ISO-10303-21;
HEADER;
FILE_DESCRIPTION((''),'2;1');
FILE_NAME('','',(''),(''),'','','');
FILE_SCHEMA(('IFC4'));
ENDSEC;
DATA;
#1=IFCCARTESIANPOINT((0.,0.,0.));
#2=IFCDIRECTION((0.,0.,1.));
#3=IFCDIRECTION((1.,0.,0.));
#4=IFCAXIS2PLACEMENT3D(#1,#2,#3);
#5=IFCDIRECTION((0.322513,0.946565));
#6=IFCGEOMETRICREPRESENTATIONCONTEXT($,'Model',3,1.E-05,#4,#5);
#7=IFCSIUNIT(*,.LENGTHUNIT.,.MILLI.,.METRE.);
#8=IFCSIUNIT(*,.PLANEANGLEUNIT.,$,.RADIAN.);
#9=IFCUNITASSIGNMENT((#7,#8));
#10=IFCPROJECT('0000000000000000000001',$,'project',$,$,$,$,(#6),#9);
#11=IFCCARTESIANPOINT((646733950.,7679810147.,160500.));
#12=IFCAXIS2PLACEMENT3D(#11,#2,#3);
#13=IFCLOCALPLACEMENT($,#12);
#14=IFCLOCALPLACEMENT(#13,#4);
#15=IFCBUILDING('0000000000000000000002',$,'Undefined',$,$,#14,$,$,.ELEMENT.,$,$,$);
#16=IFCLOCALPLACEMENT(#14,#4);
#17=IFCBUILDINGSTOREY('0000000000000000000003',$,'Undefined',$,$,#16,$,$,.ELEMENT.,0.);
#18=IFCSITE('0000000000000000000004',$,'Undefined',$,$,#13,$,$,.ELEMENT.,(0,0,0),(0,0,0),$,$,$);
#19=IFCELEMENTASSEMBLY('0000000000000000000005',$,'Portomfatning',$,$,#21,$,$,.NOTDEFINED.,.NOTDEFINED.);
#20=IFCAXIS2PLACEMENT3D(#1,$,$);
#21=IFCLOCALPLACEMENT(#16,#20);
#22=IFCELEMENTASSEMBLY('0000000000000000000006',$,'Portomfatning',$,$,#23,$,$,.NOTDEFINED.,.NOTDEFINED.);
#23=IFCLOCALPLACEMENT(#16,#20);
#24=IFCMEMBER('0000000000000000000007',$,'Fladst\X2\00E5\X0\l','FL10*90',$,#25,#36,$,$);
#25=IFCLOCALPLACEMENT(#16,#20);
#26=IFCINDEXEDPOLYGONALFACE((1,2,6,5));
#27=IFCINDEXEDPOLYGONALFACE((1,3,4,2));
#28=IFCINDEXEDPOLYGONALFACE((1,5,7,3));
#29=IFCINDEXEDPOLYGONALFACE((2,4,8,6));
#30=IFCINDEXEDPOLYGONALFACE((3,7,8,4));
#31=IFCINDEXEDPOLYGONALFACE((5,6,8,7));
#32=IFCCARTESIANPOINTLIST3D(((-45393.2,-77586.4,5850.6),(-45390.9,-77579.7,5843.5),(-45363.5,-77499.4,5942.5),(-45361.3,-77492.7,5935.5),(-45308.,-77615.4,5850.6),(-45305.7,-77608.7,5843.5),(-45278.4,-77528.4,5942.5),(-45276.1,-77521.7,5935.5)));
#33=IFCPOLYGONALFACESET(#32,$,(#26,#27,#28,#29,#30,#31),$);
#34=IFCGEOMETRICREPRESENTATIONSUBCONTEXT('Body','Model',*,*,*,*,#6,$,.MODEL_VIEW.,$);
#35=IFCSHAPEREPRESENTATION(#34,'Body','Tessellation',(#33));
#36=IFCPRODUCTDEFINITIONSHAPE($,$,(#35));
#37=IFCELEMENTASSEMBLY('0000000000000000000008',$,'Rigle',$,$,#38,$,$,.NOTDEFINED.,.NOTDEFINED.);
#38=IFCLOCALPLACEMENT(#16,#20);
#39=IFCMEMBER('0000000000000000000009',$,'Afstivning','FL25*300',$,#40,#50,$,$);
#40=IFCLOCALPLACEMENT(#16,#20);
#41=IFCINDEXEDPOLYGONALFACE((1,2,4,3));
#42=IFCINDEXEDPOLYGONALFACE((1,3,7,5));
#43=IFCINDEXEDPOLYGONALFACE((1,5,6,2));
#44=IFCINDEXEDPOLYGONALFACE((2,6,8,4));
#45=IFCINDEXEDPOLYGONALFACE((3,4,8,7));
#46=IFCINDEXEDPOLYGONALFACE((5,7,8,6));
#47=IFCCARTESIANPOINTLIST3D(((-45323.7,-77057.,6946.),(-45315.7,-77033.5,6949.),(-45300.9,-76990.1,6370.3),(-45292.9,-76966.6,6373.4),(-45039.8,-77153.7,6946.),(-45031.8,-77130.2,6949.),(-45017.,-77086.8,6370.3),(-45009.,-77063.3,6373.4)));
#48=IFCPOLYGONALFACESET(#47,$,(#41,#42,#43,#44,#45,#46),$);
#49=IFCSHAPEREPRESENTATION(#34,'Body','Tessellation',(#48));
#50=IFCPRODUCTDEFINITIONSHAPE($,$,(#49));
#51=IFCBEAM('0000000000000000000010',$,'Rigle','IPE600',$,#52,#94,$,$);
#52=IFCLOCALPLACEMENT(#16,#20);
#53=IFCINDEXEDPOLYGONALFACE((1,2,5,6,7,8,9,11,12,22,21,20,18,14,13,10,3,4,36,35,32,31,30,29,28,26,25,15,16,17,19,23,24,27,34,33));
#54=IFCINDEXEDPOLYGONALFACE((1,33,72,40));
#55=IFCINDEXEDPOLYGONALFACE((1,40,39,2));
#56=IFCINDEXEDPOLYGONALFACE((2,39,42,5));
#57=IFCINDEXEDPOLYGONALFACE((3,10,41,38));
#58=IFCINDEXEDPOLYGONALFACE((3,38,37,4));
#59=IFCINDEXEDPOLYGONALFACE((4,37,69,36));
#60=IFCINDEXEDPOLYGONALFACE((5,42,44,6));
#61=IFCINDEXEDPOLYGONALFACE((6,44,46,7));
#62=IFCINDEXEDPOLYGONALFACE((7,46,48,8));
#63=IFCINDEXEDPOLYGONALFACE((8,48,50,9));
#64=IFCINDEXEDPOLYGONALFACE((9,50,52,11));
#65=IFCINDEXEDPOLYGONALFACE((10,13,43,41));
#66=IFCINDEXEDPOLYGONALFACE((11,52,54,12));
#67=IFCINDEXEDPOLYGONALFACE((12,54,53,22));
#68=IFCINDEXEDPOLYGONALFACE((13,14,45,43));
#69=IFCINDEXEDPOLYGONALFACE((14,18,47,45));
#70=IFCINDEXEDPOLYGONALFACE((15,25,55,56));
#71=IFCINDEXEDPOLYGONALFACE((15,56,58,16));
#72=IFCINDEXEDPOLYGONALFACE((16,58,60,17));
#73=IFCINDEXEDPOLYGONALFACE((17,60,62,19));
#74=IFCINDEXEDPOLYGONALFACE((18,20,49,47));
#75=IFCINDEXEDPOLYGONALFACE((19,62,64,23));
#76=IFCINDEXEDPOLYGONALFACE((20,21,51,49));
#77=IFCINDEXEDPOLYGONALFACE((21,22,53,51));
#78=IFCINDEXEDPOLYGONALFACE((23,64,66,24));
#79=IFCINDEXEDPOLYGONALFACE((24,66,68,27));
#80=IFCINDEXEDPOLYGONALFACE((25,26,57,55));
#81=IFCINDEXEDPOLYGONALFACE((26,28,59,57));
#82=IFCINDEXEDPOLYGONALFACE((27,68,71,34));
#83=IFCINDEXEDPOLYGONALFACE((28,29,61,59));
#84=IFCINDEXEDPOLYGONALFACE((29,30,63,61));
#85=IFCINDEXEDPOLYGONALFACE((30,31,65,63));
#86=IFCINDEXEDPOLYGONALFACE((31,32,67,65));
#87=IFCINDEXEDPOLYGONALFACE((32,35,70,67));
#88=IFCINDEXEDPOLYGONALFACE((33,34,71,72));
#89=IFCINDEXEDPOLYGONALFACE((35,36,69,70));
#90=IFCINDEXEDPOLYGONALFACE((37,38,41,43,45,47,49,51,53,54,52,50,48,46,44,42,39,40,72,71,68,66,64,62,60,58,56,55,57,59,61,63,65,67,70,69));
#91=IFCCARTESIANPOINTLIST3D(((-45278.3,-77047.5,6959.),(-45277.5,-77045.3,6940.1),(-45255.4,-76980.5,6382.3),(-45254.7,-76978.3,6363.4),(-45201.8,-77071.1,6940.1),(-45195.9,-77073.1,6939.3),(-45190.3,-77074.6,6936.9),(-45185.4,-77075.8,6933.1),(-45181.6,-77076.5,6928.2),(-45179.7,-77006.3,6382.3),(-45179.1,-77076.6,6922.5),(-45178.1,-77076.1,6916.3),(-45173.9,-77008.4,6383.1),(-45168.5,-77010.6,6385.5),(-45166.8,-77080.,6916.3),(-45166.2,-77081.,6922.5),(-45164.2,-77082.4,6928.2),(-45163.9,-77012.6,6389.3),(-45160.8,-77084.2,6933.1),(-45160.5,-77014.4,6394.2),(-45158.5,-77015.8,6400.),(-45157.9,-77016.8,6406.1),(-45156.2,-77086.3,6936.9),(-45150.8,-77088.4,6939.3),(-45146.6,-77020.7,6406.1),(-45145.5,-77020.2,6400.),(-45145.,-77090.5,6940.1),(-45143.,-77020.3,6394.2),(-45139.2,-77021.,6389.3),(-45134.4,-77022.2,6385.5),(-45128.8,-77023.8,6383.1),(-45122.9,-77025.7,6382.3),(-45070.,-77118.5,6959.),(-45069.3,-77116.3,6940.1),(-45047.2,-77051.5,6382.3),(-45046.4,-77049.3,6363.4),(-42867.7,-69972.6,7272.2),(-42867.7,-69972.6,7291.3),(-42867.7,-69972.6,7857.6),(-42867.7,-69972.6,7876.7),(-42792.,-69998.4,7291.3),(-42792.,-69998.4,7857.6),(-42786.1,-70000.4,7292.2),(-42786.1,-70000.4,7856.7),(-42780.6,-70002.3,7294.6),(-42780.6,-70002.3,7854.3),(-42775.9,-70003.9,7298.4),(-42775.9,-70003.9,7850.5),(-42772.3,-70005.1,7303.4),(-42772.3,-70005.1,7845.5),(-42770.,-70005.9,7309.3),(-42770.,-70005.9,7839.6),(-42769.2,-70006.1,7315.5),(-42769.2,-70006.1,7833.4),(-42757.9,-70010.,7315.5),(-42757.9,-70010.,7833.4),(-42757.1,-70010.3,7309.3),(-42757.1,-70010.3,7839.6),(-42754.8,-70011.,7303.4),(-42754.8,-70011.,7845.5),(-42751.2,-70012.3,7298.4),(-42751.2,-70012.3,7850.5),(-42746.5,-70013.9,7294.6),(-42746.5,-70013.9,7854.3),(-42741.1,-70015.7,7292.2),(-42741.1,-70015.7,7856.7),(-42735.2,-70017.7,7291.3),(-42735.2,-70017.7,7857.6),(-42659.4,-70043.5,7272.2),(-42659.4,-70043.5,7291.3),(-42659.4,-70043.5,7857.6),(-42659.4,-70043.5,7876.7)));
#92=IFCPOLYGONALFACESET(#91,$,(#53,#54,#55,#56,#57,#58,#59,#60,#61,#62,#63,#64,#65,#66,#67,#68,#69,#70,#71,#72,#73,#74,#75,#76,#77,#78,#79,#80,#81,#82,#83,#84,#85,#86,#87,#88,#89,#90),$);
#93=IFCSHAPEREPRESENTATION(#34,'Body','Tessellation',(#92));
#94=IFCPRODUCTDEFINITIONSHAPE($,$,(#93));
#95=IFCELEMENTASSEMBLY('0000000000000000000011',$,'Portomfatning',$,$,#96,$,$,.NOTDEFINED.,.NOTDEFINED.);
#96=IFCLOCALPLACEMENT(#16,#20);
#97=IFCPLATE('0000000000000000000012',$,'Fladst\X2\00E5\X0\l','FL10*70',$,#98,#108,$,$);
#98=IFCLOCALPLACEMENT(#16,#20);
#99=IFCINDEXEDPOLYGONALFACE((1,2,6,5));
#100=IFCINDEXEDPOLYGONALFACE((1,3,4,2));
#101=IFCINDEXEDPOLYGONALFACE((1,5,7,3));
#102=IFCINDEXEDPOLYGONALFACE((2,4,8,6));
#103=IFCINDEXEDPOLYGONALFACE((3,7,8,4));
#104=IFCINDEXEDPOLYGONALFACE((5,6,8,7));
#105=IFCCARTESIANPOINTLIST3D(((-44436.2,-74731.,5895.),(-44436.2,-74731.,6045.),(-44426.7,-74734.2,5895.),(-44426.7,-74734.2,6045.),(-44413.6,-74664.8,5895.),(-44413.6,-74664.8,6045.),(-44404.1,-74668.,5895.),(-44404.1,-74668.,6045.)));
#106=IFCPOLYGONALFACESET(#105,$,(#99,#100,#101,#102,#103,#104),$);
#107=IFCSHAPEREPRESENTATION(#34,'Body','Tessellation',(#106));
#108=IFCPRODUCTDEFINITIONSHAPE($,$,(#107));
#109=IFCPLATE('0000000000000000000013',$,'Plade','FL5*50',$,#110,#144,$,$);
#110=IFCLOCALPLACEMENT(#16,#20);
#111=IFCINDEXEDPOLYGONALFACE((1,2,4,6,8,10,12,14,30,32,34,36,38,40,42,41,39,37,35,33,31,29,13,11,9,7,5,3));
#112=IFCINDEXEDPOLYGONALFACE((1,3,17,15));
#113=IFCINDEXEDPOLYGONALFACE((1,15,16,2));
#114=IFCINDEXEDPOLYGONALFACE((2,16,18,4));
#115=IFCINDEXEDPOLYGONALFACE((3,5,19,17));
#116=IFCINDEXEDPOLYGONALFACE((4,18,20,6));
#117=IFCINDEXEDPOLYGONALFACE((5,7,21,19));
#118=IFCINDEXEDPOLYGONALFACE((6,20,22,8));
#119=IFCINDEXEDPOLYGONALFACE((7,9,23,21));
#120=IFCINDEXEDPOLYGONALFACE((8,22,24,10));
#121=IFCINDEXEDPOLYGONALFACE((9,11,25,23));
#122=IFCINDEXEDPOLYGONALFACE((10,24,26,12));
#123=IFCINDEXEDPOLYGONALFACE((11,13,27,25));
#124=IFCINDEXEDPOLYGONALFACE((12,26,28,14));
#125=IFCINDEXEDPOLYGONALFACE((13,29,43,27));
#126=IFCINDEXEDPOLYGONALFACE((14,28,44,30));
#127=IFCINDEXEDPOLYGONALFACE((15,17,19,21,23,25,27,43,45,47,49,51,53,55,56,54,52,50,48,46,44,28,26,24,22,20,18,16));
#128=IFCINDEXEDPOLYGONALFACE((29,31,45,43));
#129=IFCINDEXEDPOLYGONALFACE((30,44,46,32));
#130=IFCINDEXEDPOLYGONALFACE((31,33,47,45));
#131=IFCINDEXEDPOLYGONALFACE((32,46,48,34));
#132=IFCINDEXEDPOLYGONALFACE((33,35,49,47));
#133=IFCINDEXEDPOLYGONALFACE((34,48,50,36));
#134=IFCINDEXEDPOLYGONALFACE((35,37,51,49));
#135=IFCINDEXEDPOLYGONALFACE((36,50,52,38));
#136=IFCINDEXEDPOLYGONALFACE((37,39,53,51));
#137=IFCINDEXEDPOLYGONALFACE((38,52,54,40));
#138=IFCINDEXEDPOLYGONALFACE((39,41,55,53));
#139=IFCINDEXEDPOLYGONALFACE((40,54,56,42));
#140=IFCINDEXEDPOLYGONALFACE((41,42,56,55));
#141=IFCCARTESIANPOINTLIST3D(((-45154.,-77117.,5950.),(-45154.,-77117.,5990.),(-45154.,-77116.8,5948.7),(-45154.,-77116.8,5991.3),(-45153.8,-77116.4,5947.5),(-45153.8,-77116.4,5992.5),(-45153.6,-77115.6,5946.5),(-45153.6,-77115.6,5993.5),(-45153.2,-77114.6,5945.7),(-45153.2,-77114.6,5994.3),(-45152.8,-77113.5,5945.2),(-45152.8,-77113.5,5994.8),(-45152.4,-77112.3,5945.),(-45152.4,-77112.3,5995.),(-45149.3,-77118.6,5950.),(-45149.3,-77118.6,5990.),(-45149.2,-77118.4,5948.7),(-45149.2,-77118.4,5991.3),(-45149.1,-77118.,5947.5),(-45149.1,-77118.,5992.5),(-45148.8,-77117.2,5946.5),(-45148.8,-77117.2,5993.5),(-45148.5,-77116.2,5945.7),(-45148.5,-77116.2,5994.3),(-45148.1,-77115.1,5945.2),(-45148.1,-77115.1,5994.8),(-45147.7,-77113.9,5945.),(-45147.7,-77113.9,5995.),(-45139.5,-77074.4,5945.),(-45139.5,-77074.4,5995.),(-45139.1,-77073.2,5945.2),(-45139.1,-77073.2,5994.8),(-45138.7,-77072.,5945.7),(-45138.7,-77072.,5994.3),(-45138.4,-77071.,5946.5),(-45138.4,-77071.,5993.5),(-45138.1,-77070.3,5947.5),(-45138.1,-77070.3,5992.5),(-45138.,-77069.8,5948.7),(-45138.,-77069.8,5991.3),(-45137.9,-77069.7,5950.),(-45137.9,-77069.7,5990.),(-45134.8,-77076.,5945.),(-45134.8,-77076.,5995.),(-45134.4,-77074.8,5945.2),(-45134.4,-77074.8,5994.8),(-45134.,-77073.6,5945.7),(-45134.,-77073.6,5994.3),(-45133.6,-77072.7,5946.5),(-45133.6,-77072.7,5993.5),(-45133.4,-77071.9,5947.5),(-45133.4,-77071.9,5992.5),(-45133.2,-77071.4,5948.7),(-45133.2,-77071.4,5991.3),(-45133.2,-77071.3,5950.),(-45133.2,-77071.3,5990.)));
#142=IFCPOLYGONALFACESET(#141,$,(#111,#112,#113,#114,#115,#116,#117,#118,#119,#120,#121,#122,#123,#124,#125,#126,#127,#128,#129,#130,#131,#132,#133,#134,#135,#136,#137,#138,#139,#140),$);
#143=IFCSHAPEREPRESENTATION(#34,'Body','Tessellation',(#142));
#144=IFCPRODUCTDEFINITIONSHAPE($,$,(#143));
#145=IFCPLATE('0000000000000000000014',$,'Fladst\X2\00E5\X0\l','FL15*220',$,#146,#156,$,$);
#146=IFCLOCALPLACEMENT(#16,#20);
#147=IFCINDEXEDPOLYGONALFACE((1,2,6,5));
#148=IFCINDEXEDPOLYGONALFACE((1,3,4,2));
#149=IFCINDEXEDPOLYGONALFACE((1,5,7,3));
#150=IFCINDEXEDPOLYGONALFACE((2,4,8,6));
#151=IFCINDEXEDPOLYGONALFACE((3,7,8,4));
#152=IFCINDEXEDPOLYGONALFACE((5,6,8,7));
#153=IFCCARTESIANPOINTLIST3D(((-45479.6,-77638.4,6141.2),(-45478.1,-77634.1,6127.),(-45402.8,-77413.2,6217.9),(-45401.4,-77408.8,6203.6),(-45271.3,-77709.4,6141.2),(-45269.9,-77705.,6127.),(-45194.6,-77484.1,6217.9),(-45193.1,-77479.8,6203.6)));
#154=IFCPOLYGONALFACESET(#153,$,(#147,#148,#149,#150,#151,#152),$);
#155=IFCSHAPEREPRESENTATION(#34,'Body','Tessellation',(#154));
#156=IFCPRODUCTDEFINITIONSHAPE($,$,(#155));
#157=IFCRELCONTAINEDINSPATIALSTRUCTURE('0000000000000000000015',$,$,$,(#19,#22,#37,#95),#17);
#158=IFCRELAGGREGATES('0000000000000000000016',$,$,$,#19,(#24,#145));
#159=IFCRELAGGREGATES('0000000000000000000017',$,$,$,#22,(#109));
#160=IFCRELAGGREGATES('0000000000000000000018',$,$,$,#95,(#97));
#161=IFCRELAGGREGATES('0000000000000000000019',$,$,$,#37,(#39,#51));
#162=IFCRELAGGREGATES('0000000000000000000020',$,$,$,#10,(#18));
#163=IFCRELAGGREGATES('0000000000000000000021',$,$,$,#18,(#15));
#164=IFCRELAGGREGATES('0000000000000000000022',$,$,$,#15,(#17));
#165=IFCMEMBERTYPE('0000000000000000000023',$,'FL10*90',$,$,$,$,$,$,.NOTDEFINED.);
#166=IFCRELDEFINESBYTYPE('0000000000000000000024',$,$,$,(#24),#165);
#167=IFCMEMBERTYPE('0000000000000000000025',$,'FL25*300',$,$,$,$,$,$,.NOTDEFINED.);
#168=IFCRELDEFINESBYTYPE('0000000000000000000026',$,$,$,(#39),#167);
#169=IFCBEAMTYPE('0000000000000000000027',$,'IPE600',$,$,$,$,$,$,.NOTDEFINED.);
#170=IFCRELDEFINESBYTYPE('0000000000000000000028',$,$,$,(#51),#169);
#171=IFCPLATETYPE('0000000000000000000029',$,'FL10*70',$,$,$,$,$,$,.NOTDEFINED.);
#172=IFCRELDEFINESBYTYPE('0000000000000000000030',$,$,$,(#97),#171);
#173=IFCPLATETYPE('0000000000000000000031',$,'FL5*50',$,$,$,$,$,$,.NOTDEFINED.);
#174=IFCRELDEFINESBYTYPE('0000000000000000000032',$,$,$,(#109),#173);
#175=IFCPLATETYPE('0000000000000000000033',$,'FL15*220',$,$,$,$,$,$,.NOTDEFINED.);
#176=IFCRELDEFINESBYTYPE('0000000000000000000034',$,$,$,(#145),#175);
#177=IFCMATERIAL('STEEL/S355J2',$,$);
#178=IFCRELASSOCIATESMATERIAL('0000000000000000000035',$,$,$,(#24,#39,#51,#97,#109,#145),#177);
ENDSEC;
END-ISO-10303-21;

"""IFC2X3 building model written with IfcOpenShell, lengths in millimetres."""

from ifc_helpers import new_model, si_unit, direction, frame, frame_2d, origin_with_axes, origin_2d_with_axis, place, context, subcontext, project, spatial, polyline, circle_curve, parameter, trimmed, segment, composite_curve, rectangle, i_section, outline, extrude, clip, halfspace, material, type_object, element, aggregate, save


model = new_model("IFC2X3")

# Units and contexts
model_context = context("Model", 3, precision=1e-05, world=origin_with_axes(), true_north=direction((0.322513, 0.946565)))
body_context = subcontext(model_context, "Body", "Model", "MODEL_VIEW")
ifc_project = project(units=[si_unit("LENGTHUNIT", "METRE", prefix="MILLI"), si_unit("PLANEANGLEUNIT", "RADIAN")], contexts=[model_context])

# Site, building, storey
site_placement = place(None, frame((646733950.0, 7679810147.0, 160500.0), z_axis=(0.0, 0.0, 1.0), x_axis=(1.0, 0.0, 0.0)))
site = spatial("IfcSite", under=ifc_project, at=site_placement, Name="Undefined", CompositionType="ELEMENT", RefLatitude=(0, 0, 0), RefLongitude=(0, 0, 0))
building_placement = place(site_placement, origin_with_axes())
building = spatial("IfcBuilding", under=site, at=building_placement, Name="Undefined", CompositionType="ELEMENT")
storey_placement = place(building_placement, origin_with_axes())
storey = spatial("IfcBuildingStorey", under=building, at=storey_placement, Name="Undefined", CompositionType="ELEMENT", Elevation=0.0)

# Element assembly
assembly_1_placement = place(storey_placement, origin_with_axes())
assembly_1 = element("IfcElementAssembly", 1, at=assembly_1_placement, inside=storey, Name="Portomfatning", AssemblyPlace="NOTDEFINED", PredefinedType="NOTDEFINED")

# Element assembly
assembly_2_placement = place(storey_placement, origin_with_axes())
assembly_2 = element("IfcElementAssembly", 2, at=assembly_2_placement, inside=storey, Name="Portomfatning", AssemblyPlace="NOTDEFINED", PredefinedType="NOTDEFINED")

# Member
ifc_material_1 = material(Name="STEEL/S355J2")
member_type_1 = type_object("IfcMemberType", Name="FL10*90", PredefinedType="NOTDEFINED")
member_1_placement = place(assembly_1_placement, frame((-45349.5, -77597.6, 5847.1), z_axis=(0.946565, -0.322513, 0.0), x_axis=(0.228051, 0.669323, 0.707107)))
member_1 = element("IfcMember", 3, at=member_1_placement, type_object=member_type_1, material=ifc_material_1, Name="Fladstål", Description="FL10*90", context=body_context, shape_type="SweptSolid", body=[
    extrude(rectangle(XDim=10.0, YDim=90.0, at=origin_2d_with_axis()), frame((130.0, 0.0, 0.0), z_axis=(-1.0, 0.0, 0.0), x_axis=(0.0, -1.0, 0.0)), (0.0, 0.0, 1.0), 130.0),
])

# Element assembly, member, beam
assembly_3_placement = place(storey_placement, origin_with_axes())
assembly_3 = element("IfcElementAssembly", 4, at=assembly_3_placement, inside=storey, Name="Rigle", AssemblyPlace="NOTDEFINED", PredefinedType="NOTDEFINED")
member_type_2 = type_object("IfcMemberType", Name="FL25*300", PredefinedType="NOTDEFINED")
member_2_placement = place(assembly_3_placement, frame((-45177.7, -77093.6, 6947.5), z_axis=(0.946565, -0.322513, 0.0), x_axis=(0.039304, 0.115357, -0.992546)))
member_2 = element("IfcMember", 5, at=member_2_placement, type_object=member_type_2, material=ifc_material_1, Name="Afstivning", Description="FL25*300", context=body_context, shape_type="SweptSolid", body=[
    extrude(rectangle(XDim=25.0, YDim=300.0, at=origin_2d_with_axis()), frame((580.0, 0.0, 0.0), z_axis=(-1.0, 0.0, 0.0), x_axis=(0.0, -1.0, 0.0)), (0.0, 0.0, 1.0), 580.0),
])
beam_type_1 = type_object("IfcBeamType", Name="IPE600", PredefinedType="NOTDEFINED")
beam_1_placement = place(assembly_3_placement, frame((-45166.3, -77060.1, 6659.7), z_axis=(-0.039304, -0.115357, 0.992546), x_axis=(0.320109, 0.93951, 0.121869)))
beam_1 = element("IfcBeam", 6, at=beam_1_placement, type_object=beam_type_1, material=ifc_material_1, Name="Rigle", Description="IPE600", context=body_context, shape_type="Clipping", body=[
    clip(clip(extrude(i_section(OverallWidth=220.0, OverallDepth=600.0, WebThickness=12.0, FlangeThickness=19.0, FilletRadius=24.0, at=origin_2d_with_axis()), frame((7751.3, 0.0, 0.0), z_axis=(-1.0, 0.0, 0.0), x_axis=(0.0, -1.0, 0.0)), (0.0, 0.0, 1.0), 7983.9), halfspace(frame((7543.3, 0.0, 303.0), z_axis=(0.992546, 0.0, -0.121869), x_axis=(0.0, 1.0, 0.0)), False)), halfspace(frame((12.5, 0.0, 0.0), z_axis=(-1.0, 0.0, 0.0), x_axis=(0.0, 1.0, 0.0)), False)),
])

# Element assembly, plate
assembly_4_placement = place(storey_placement, origin_with_axes())
assembly_4 = element("IfcElementAssembly", 7, at=assembly_4_placement, inside=storey, Name="Portomfatning", AssemblyPlace="NOTDEFINED", PredefinedType="NOTDEFINED")
plate_type_1 = type_object("IfcPlateType", Name="FL10*70", PredefinedType="NOTDEFINED")
plate_1_placement = place(assembly_4_placement, frame((-44420.1, -74699.5, 5895.0), z_axis=(-0.946565, 0.322513, 0.0), x_axis=(0.0, 0.0, 1.0)))
plate_1 = element("IfcPlate", 8, at=plate_1_placement, type_object=plate_type_1, material=ifc_material_1, Name="Fladstål", Description="FL10*70", context=body_context, shape_type="SweptSolid", body=[
    extrude(outline(polyline([(0.0, -35.0), (0.0, 35.0), (150.0, 35.0), (150.0, -35.0), (0.0, -35.0)])), frame((0.0, 0.0, -5.0), z_axis=(0.0, 0.0, 1.0), x_axis=(1.0, 0.0, 0.0)), (0.0, 0.0, 1.0), 10.0),
])

# Plates
plate_type_2 = type_object("IfcPlateType", Name="FL5*50", PredefinedType="NOTDEFINED")
plate_2_placement = place(assembly_2_placement, frame((-45135.5, -77070.5, 5995.0), z_axis=(0.946565, -0.322513, 0.0), x_axis=(-0.322513, -0.946565, 0.0)))
plate_2 = element("IfcPlate", 9, at=plate_2_placement, type_object=plate_type_2, material=ifc_material_1, Name="Plade", Description="FL5*50", context=body_context, shape_type="SweptSolid", body=[
    extrude(outline(composite_curve([segment(trimmed(circle_curve(frame_2d((5.0, 5.0), x_axis=(-1.0, 0.0)), 5.0), [parameter(0.0)], [parameter(1.570796)], True, "PARAMETER"), True, "CONTINUOUS"), segment(polyline([(5.0, 0.0), (45.0, 0.0)]), True, "CONTINUOUS"), segment(trimmed(circle_curve(frame_2d((45.0, 5.0), x_axis=(0.0, -1.0)), 5.0), [parameter(0.0)], [parameter(1.570796)], True, "PARAMETER"), True, "CONTINUOUS"), segment(polyline([(50.0, 5.0), (50.0, 45.0)]), True, "CONTINUOUS"), segment(trimmed(circle_curve(frame_2d((45.0, 45.0), x_axis=(1.0, 0.0)), 5.0), [parameter(0.0)], [parameter(1.570796)], True, "PARAMETER"), True, "CONTINUOUS"), segment(polyline([(45.0, 50.0), (5.0, 50.0)]), True, "CONTINUOUS"), segment(trimmed(circle_curve(frame_2d((5.0, 45.0), x_axis=(0.0, 1.0)), 5.0), [parameter(0.0)], [parameter(1.570796)], True, "PARAMETER"), True, "CONTINUOUS"), segment(polyline([(0.0, 45.0), (0.0, 5.0)]), True, "CONTINUOUS")], self_intersect=True)), frame((0.0, 0.0, -2.5), z_axis=(0.0, 0.0, 1.0), x_axis=(1.0, 0.0, 0.0)), (0.0, 0.0, 1.0), 5.0),
])
plate_type_3 = type_object("IfcPlateType", Name="FL15*220", PredefinedType="NOTDEFINED")
plate_3_placement = place(assembly_1_placement, frame((-45374.7, -77671.7, 6134.1), z_axis=(0.098895, 0.290253, -0.951826), x_axis=(0.306976, 0.900965, 0.306638)))
plate_3 = element("IfcPlate", 10, at=plate_3_placement, type_object=plate_type_3, material=ifc_material_1, Name="Fladstål", Description="FL15*220", context=body_context, shape_type="SweptSolid", body=[
    extrude(outline(polyline([(0.0, -110.0), (0.0, 110.0), (250.0, 110.0), (250.0, -110.0), (0.0, -110.0)])), frame((0.0, 0.0, -7.5), z_axis=(0.0, 0.0, 1.0), x_axis=(1.0, 0.0, 0.0)), (0.0, 0.0, 1.0), 15.0),
])

aggregate(assembly_1, [member_1, plate_3])

aggregate(assembly_2, [plate_2])
aggregate(assembly_4, [plate_1])
aggregate(assembly_3, [member_2, beam_1])

save(model, "model.ifc")
